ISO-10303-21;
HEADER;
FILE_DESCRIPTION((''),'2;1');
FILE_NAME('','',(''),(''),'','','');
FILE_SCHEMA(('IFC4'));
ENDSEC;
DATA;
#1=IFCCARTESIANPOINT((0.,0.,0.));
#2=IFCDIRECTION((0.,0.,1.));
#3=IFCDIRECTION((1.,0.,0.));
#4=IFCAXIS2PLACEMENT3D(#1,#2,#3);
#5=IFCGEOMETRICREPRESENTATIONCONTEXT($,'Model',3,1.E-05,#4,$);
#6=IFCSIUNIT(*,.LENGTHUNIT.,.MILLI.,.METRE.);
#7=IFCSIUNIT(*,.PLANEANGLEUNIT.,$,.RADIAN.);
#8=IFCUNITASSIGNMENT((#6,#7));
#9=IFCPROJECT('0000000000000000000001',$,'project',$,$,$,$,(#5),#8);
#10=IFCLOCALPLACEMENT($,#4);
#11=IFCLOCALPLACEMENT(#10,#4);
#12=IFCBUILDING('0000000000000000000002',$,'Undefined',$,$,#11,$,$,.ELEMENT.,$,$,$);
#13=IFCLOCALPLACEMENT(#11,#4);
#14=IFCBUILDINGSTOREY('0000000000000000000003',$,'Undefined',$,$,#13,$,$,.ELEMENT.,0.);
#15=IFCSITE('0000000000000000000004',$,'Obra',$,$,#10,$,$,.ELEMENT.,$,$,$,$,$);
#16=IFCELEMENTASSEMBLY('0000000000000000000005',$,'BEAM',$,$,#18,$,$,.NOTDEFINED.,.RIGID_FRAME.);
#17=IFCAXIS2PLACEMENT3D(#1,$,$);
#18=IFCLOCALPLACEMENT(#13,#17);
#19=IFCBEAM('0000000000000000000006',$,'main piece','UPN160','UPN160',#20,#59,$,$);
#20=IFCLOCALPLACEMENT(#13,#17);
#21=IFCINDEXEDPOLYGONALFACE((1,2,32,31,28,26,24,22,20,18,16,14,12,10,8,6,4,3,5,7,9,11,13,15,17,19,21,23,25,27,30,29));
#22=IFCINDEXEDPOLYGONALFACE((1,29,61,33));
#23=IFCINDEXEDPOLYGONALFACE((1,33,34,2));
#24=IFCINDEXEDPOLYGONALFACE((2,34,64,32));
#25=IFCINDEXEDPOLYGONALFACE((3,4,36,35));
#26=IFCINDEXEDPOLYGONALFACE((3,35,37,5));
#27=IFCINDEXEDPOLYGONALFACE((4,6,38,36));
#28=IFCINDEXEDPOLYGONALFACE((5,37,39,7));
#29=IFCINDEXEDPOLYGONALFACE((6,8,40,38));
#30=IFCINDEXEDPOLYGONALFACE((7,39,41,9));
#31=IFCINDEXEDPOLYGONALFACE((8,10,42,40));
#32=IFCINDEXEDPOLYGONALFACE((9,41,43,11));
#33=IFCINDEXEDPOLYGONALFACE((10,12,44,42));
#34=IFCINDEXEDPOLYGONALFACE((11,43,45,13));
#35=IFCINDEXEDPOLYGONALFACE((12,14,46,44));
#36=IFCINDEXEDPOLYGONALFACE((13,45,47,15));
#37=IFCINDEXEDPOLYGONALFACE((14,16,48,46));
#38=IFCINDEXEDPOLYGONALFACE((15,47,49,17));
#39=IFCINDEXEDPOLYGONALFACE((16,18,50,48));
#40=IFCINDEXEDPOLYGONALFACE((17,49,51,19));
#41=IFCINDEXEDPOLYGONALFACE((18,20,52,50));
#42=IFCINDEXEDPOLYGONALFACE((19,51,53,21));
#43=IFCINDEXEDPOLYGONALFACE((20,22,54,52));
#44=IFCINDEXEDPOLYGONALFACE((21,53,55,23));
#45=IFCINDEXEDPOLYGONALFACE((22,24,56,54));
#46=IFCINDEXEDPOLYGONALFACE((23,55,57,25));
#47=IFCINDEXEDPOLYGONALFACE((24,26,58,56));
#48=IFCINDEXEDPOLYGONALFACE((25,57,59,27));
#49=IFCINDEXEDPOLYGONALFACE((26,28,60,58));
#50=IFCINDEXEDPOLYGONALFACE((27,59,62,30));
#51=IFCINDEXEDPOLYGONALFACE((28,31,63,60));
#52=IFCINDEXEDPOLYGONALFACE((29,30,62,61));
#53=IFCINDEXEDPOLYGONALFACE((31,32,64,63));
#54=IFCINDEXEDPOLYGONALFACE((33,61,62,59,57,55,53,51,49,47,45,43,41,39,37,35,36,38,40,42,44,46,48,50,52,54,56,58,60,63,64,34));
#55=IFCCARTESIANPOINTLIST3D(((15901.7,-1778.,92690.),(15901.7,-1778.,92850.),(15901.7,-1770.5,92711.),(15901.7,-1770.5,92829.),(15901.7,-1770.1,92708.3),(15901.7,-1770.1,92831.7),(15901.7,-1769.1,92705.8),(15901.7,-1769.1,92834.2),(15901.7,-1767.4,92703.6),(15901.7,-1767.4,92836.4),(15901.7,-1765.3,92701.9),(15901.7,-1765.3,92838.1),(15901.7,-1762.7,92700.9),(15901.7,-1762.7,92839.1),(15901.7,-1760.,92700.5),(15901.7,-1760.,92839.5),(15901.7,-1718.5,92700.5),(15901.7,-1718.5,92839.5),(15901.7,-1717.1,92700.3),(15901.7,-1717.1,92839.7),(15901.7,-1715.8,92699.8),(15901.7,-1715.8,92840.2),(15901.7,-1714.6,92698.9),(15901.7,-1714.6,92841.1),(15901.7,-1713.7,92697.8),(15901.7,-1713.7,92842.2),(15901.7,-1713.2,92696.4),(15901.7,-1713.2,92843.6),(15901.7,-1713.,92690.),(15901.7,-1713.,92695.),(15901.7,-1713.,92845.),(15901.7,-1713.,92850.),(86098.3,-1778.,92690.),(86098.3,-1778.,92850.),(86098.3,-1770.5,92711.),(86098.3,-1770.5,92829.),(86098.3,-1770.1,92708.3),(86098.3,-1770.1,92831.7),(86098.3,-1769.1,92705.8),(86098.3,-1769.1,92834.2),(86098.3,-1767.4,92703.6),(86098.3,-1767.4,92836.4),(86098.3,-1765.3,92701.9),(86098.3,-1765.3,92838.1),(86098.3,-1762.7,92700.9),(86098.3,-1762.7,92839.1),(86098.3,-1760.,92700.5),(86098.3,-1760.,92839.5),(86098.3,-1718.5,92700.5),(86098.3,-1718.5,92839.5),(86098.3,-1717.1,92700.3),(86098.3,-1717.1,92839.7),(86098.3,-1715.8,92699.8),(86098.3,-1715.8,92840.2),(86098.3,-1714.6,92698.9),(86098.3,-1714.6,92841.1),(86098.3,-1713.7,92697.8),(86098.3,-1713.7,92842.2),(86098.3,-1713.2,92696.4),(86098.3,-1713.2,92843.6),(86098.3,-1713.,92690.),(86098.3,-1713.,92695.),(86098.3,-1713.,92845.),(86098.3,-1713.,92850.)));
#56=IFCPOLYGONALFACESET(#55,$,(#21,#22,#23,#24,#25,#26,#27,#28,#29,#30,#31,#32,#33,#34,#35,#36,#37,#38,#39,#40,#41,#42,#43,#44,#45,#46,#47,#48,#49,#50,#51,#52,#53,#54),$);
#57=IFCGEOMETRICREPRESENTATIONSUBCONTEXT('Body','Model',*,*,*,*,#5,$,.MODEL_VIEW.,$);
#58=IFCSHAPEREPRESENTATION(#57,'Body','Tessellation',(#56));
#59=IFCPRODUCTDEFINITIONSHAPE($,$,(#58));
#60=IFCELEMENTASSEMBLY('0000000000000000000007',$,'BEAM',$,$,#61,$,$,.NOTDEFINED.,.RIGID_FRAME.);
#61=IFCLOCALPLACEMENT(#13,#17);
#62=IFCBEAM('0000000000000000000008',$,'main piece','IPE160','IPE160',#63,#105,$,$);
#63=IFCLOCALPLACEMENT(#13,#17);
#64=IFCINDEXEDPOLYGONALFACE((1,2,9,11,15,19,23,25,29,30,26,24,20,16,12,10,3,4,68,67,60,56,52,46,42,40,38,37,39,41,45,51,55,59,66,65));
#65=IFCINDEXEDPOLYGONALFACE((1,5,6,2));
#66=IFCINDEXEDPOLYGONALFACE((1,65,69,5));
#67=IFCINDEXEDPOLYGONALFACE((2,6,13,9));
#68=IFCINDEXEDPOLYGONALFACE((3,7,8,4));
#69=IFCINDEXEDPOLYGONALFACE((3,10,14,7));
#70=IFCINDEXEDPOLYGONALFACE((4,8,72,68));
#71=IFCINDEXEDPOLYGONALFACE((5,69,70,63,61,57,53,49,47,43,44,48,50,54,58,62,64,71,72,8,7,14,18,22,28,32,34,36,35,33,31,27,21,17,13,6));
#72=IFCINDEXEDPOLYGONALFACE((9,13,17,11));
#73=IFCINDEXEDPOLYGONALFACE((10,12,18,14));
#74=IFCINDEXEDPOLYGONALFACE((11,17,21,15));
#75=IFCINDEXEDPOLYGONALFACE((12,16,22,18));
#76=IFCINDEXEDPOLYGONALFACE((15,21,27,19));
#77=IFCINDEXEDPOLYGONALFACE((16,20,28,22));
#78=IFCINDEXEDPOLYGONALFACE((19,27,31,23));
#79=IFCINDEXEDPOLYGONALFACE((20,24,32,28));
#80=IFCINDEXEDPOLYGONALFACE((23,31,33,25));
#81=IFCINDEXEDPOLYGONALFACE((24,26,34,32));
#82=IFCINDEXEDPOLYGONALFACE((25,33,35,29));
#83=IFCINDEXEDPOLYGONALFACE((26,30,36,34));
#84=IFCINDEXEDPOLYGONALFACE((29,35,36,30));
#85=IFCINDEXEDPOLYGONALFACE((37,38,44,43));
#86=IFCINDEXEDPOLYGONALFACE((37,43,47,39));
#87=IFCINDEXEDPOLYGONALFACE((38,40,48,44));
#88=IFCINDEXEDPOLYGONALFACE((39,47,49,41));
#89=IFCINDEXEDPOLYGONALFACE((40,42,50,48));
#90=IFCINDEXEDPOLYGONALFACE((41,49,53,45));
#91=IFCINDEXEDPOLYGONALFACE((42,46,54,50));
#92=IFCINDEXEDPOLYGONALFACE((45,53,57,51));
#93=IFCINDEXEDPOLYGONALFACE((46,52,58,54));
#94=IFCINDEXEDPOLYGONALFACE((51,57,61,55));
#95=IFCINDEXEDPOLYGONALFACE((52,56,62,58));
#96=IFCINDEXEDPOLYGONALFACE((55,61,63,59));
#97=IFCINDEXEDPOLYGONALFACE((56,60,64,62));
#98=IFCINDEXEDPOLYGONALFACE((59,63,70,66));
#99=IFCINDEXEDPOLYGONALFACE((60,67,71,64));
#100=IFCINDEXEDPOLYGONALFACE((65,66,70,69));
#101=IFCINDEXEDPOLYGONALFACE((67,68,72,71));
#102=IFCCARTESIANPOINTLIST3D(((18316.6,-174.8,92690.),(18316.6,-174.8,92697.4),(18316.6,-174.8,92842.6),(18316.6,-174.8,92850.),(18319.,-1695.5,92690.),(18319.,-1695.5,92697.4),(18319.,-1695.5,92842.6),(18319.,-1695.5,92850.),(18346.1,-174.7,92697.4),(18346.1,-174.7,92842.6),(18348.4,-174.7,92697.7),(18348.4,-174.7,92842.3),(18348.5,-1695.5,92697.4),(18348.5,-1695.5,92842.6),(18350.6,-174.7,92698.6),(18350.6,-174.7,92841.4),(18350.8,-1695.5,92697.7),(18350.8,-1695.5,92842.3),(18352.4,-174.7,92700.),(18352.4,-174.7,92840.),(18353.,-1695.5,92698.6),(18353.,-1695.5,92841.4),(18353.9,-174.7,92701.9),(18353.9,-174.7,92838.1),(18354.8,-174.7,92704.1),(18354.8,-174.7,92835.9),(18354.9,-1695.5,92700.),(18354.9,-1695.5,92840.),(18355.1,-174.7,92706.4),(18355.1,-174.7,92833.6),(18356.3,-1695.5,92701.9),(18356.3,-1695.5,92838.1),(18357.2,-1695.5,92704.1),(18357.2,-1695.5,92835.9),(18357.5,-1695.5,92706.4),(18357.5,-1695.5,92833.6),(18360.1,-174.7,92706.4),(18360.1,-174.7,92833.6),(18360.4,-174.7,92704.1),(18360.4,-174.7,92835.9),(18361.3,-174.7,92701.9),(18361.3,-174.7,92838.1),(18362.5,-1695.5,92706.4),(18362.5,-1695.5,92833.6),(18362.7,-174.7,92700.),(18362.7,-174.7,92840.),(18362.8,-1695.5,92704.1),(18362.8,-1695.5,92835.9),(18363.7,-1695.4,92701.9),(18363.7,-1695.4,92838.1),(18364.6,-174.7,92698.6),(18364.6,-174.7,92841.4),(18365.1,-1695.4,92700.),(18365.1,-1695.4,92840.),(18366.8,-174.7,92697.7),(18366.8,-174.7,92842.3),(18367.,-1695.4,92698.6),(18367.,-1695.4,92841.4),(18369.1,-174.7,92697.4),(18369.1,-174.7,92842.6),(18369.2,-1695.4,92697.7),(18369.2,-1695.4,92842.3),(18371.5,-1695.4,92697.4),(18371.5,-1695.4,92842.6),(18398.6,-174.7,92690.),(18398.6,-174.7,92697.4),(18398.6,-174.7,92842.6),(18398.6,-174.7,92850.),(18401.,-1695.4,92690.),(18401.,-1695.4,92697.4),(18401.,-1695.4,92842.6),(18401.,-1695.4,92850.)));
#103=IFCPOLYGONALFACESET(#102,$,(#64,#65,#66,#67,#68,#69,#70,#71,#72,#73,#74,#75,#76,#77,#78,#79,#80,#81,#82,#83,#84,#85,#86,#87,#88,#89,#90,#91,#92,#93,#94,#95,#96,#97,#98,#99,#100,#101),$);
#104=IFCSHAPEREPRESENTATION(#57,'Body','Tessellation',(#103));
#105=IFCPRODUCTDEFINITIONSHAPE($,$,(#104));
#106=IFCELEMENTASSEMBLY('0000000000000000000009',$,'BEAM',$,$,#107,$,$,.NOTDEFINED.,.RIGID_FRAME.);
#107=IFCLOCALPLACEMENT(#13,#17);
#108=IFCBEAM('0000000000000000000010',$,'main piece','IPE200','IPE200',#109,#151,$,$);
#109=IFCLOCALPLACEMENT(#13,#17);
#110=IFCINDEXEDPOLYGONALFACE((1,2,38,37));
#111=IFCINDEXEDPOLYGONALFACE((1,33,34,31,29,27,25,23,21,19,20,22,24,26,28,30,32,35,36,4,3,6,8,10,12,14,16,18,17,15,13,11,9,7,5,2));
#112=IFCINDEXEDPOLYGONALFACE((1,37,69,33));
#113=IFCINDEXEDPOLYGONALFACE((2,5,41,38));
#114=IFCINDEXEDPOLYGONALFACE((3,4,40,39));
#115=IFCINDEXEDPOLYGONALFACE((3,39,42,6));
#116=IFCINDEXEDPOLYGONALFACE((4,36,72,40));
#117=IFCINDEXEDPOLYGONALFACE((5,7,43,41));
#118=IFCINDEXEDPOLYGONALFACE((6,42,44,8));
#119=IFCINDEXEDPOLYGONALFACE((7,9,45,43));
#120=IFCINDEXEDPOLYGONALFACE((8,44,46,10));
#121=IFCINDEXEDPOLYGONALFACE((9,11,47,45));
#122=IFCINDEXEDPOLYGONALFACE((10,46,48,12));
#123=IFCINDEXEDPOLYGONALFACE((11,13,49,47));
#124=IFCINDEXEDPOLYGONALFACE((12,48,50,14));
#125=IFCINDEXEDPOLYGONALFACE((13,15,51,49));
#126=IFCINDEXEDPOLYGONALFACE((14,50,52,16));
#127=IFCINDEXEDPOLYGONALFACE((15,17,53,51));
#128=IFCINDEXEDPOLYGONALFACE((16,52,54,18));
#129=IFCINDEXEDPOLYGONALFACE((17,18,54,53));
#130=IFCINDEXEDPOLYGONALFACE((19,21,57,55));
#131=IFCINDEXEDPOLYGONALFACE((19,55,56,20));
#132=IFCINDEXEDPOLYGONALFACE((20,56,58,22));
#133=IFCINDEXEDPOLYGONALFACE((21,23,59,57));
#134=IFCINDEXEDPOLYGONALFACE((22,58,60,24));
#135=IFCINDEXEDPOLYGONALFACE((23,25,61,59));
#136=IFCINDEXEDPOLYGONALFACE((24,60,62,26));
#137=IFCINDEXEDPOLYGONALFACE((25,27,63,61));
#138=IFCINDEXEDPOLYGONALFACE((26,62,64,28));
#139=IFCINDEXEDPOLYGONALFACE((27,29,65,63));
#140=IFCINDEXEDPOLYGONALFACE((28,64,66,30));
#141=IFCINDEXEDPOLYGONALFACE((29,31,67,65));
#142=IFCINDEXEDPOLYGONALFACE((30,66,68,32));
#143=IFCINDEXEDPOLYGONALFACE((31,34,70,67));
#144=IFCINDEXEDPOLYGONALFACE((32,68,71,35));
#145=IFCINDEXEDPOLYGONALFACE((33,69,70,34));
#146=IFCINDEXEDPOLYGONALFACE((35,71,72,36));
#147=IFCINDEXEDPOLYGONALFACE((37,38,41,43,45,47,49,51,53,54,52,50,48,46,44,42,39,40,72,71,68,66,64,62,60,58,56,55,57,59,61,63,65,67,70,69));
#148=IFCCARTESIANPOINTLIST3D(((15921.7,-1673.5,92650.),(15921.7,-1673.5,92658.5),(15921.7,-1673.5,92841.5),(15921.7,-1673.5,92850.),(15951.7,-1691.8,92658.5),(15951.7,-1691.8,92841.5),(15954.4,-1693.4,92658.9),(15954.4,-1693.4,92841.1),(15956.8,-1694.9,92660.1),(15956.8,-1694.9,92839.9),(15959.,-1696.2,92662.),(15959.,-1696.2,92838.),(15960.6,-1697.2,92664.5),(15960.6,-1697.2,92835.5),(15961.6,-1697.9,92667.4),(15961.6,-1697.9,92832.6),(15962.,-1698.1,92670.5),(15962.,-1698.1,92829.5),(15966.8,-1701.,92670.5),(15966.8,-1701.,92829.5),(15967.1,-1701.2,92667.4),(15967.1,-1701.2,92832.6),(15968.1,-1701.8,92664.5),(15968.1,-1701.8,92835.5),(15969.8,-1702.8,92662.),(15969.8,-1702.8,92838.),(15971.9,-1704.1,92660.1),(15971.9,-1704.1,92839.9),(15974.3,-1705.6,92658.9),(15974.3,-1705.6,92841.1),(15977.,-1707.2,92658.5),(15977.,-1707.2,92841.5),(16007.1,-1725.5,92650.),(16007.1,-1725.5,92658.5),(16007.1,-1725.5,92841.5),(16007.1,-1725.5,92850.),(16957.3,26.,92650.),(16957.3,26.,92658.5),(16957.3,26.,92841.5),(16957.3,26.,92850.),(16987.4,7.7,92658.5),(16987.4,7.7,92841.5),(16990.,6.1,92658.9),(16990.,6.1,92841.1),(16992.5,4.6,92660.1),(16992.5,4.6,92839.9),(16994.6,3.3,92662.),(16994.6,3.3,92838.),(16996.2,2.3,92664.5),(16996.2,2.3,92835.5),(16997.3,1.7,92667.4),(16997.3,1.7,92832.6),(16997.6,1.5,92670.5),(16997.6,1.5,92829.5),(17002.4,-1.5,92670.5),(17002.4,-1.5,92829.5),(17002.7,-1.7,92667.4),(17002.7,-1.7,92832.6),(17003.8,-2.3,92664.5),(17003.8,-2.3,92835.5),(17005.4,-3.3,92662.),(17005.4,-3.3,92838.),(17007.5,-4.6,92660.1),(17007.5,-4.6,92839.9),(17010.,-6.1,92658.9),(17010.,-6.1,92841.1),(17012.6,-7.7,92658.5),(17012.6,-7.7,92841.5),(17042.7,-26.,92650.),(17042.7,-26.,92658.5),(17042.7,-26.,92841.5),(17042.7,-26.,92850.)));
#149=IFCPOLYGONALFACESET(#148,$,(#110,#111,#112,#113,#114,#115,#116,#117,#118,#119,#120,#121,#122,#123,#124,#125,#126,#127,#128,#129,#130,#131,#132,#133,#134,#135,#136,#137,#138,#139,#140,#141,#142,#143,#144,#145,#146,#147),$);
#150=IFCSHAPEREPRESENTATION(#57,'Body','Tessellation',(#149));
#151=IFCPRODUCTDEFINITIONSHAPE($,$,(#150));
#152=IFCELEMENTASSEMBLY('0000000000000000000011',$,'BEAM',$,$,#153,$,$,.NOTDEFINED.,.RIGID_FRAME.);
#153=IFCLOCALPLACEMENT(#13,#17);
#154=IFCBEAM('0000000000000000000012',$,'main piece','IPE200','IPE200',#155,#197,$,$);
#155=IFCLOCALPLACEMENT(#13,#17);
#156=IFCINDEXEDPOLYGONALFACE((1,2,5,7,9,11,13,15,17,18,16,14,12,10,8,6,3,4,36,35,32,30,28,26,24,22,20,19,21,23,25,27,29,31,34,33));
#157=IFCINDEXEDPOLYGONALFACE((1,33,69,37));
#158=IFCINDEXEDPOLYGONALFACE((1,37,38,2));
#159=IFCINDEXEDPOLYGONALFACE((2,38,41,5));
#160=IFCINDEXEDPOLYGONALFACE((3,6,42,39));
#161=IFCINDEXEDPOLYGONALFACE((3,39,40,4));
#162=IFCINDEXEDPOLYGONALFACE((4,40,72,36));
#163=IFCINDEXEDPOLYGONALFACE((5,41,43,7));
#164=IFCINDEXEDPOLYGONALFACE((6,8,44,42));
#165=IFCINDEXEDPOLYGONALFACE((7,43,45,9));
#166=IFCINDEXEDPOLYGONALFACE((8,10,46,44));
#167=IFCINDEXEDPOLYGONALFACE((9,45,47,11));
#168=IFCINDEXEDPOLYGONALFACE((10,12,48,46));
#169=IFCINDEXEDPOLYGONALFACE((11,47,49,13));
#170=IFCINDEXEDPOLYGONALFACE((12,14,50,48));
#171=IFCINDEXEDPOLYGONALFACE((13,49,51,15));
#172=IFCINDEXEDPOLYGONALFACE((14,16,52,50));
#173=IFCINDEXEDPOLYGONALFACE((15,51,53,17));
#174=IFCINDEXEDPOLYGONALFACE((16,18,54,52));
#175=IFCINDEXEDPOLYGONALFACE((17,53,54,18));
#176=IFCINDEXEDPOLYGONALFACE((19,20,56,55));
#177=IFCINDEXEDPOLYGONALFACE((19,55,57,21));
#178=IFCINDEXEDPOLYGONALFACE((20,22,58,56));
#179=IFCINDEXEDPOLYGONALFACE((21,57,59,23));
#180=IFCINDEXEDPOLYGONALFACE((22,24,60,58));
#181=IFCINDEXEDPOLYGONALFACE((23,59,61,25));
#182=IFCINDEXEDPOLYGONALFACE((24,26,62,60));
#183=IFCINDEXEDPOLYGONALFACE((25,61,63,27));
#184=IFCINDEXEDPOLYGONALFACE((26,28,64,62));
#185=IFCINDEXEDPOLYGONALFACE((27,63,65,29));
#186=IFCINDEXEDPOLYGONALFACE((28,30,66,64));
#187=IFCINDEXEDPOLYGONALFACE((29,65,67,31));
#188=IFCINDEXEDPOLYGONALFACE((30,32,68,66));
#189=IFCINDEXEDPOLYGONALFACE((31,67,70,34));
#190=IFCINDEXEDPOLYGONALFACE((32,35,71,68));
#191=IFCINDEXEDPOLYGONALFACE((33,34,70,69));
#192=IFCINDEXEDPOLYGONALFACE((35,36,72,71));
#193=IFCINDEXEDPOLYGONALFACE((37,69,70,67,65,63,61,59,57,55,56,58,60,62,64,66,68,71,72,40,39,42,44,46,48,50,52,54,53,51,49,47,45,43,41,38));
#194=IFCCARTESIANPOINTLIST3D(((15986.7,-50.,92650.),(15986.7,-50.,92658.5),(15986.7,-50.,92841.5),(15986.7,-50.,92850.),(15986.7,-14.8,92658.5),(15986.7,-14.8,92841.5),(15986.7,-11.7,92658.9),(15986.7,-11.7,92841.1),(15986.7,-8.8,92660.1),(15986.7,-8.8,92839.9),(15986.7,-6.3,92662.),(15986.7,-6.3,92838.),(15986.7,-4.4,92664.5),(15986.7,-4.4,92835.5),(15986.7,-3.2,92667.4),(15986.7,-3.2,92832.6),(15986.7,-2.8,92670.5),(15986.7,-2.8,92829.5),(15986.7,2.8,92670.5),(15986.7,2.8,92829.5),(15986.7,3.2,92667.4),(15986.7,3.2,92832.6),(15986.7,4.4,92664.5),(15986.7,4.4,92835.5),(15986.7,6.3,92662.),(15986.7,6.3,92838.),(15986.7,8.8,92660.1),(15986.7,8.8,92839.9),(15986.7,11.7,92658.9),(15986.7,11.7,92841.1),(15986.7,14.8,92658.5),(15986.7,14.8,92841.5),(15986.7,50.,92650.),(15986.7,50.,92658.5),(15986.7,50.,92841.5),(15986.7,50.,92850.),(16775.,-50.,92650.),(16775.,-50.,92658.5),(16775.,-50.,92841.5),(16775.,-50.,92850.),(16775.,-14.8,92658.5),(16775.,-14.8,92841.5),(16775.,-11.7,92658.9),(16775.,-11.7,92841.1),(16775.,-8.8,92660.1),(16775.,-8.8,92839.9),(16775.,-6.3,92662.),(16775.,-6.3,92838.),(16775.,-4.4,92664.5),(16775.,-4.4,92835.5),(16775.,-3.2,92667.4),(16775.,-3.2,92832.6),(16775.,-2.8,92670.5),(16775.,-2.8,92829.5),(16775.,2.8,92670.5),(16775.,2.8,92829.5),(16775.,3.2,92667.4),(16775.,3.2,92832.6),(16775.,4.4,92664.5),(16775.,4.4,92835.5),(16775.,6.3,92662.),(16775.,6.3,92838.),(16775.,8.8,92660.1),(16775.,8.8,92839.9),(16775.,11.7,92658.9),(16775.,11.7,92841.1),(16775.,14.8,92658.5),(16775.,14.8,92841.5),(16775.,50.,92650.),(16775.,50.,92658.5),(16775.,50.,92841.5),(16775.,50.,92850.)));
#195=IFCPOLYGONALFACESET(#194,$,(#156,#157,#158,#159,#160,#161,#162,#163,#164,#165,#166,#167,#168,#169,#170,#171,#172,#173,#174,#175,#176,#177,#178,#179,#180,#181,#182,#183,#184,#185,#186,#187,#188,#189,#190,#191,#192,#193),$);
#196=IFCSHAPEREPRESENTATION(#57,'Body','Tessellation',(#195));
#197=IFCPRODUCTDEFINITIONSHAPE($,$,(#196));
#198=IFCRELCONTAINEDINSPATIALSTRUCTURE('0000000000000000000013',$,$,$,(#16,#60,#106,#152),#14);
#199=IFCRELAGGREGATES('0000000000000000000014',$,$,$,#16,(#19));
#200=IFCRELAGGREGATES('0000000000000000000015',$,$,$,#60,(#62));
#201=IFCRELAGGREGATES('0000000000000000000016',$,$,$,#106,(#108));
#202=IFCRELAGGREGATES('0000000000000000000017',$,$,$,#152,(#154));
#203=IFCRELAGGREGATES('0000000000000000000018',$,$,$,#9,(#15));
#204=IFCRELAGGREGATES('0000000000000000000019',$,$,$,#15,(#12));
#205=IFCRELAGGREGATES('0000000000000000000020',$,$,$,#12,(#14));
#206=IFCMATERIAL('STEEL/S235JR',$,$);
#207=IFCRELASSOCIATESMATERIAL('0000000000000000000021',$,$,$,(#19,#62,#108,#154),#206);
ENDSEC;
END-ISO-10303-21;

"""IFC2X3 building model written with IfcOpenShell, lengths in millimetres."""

from ifc_helpers import new_model, si_unit, frame, origin_with_axes, origin_2d_with_axis, place, context, subcontext, project, spatial, i_section, u_section, extrude, material, element, aggregate, save


model = new_model("IFC2X3")

# Units and contexts
model_context = context("Model", 3, precision=1e-05, world=origin_with_axes())
body_context = subcontext(model_context, "Body", "Model", "MODEL_VIEW")
ifc_project = project(units=[si_unit("LENGTHUNIT", "METRE", prefix="MILLI"), si_unit("PLANEANGLEUNIT", "RADIAN")], contexts=[model_context])

# Site, building, storey
site_placement = place(None, origin_with_axes())
site = spatial("IfcSite", under=ifc_project, at=site_placement, Name="Obra", CompositionType="ELEMENT")
building_placement = place(site_placement, origin_with_axes())
building = spatial("IfcBuilding", under=site, at=building_placement, Name="Undefined", CompositionType="ELEMENT")
storey_placement = place(building_placement, origin_with_axes())
storey = spatial("IfcBuildingStorey", under=building, at=storey_placement, Name="Undefined", CompositionType="ELEMENT", Elevation=0.0)

# Element assemblies, beams
assembly_1_placement = place(storey_placement, origin_with_axes())
assembly_1 = element("IfcElementAssembly", 1, at=assembly_1_placement, inside=storey, Name="BEAM", AssemblyPlace="NOTDEFINED", PredefinedType="RIGID_FRAME")
ifc_material = material(Name="STEEL/S235JR")
beam_1_placement = place(assembly_1_placement, frame((15901.7, -1745.5, 92770.0), z_axis=(0.0, 0.0, -1.0), x_axis=(1.0, 0.0, 0.0)))
beam_1 = element("IfcBeam", 2, at=beam_1_placement, material=ifc_material, Name="main piece", Description="UPN160", ObjectType="UPN160", context=body_context, shape_type="SweptSolid", body=[
    extrude(u_section(Depth=160.0, FlangeWidth=65.0, WebThickness=7.5, FlangeThickness=10.5, FilletRadius=10.5, EdgeRadius=5.5, at=origin_2d_with_axis()), frame((70196.6, 0.0, 0.0), z_axis=(-1.0, 0.0, 0.0), x_axis=(0.0, -1.0, 0.0)), (0.0, 0.0, 1.0), 70196.6),
])
aggregate(assembly_1, [beam_1])
assembly_2_placement = place(storey_placement, origin_with_axes())
assembly_2 = element("IfcElementAssembly", 3, at=assembly_2_placement, inside=storey, Name="BEAM", AssemblyPlace="NOTDEFINED", PredefinedType="RIGID_FRAME")
beam_2_placement = place(assembly_2_placement, frame((18360.0, -1695.5, 92770.0), z_axis=(0.0, 0.0, 1.0), x_axis=(-0.001588, 0.999999, 0.0)))
beam_2 = element("IfcBeam", 4, at=beam_2_placement, material=ifc_material, Name="main piece", Description="IPE160", ObjectType="IPE160", context=body_context, shape_type="SweptSolid", body=[
    extrude(i_section(OverallWidth=82.0, OverallDepth=160.0, WebThickness=5.0, FlangeThickness=7.4, FilletRadius=9.0, at=origin_2d_with_axis()), frame((1520.7, 0.0, 0.0), z_axis=(-1.0, 0.0, 0.0), x_axis=(0.0, -1.0, 0.0)), (0.0, 0.0, 1.0), 1520.7),
])
aggregate(assembly_2, [beam_2])
assembly_3_placement = place(storey_placement, origin_with_axes())
assembly_3 = element("IfcElementAssembly", 5, at=assembly_3_placement, inside=storey, Name="BEAM", AssemblyPlace="NOTDEFINED", PredefinedType="RIGID_FRAME")
beam_3_placement = place(assembly_3_placement, frame((17000.0, 0.0, 92750.0), z_axis=(0.0, 0.0, 1.0), x_axis=(-0.520368, -0.853942, 0.0)))
beam_3 = element("IfcBeam", 6, at=beam_3_placement, material=ifc_material, Name="main piece", Description="IPE200", ObjectType="IPE200", context=body_context, shape_type="SweptSolid", body=[
    extrude(i_section(OverallWidth=100.0, OverallDepth=200.0, WebThickness=5.6, FlangeThickness=8.5, FilletRadius=12.0, at=origin_2d_with_axis()), frame((1990.2, 0.0, 0.0), z_axis=(-1.0, 0.0, 0.0), x_axis=(0.0, -1.0, 0.0)), (0.0, 0.0, 1.0), 1990.2),
])
aggregate(assembly_3, [beam_3])
assembly_4_placement = place(storey_placement, origin_with_axes())
assembly_4 = element("IfcElementAssembly", 7, at=assembly_4_placement, inside=storey, Name="BEAM", AssemblyPlace="NOTDEFINED", PredefinedType="RIGID_FRAME")
beam_4_placement = place(assembly_4_placement, frame((16775.0, 0.0, 92750.0), z_axis=(0.0, 0.0, 1.0), x_axis=(-1.0, 0.0, 0.0)))
beam_4 = element("IfcBeam", 8, at=beam_4_placement, material=ifc_material, Name="main piece", Description="IPE200", ObjectType="IPE200", context=body_context, shape_type="SweptSolid", body=[
    extrude(i_section(OverallWidth=100.0, OverallDepth=200.0, WebThickness=5.6, FlangeThickness=8.5, FilletRadius=12.0, at=origin_2d_with_axis()), frame((788.3, 0.0, 0.0), z_axis=(-1.0, 0.0, 0.0), x_axis=(0.0, -1.0, 0.0)), (0.0, 0.0, 1.0), 788.3),
])
aggregate(assembly_4, [beam_4])

save(model, "model.ifc")
